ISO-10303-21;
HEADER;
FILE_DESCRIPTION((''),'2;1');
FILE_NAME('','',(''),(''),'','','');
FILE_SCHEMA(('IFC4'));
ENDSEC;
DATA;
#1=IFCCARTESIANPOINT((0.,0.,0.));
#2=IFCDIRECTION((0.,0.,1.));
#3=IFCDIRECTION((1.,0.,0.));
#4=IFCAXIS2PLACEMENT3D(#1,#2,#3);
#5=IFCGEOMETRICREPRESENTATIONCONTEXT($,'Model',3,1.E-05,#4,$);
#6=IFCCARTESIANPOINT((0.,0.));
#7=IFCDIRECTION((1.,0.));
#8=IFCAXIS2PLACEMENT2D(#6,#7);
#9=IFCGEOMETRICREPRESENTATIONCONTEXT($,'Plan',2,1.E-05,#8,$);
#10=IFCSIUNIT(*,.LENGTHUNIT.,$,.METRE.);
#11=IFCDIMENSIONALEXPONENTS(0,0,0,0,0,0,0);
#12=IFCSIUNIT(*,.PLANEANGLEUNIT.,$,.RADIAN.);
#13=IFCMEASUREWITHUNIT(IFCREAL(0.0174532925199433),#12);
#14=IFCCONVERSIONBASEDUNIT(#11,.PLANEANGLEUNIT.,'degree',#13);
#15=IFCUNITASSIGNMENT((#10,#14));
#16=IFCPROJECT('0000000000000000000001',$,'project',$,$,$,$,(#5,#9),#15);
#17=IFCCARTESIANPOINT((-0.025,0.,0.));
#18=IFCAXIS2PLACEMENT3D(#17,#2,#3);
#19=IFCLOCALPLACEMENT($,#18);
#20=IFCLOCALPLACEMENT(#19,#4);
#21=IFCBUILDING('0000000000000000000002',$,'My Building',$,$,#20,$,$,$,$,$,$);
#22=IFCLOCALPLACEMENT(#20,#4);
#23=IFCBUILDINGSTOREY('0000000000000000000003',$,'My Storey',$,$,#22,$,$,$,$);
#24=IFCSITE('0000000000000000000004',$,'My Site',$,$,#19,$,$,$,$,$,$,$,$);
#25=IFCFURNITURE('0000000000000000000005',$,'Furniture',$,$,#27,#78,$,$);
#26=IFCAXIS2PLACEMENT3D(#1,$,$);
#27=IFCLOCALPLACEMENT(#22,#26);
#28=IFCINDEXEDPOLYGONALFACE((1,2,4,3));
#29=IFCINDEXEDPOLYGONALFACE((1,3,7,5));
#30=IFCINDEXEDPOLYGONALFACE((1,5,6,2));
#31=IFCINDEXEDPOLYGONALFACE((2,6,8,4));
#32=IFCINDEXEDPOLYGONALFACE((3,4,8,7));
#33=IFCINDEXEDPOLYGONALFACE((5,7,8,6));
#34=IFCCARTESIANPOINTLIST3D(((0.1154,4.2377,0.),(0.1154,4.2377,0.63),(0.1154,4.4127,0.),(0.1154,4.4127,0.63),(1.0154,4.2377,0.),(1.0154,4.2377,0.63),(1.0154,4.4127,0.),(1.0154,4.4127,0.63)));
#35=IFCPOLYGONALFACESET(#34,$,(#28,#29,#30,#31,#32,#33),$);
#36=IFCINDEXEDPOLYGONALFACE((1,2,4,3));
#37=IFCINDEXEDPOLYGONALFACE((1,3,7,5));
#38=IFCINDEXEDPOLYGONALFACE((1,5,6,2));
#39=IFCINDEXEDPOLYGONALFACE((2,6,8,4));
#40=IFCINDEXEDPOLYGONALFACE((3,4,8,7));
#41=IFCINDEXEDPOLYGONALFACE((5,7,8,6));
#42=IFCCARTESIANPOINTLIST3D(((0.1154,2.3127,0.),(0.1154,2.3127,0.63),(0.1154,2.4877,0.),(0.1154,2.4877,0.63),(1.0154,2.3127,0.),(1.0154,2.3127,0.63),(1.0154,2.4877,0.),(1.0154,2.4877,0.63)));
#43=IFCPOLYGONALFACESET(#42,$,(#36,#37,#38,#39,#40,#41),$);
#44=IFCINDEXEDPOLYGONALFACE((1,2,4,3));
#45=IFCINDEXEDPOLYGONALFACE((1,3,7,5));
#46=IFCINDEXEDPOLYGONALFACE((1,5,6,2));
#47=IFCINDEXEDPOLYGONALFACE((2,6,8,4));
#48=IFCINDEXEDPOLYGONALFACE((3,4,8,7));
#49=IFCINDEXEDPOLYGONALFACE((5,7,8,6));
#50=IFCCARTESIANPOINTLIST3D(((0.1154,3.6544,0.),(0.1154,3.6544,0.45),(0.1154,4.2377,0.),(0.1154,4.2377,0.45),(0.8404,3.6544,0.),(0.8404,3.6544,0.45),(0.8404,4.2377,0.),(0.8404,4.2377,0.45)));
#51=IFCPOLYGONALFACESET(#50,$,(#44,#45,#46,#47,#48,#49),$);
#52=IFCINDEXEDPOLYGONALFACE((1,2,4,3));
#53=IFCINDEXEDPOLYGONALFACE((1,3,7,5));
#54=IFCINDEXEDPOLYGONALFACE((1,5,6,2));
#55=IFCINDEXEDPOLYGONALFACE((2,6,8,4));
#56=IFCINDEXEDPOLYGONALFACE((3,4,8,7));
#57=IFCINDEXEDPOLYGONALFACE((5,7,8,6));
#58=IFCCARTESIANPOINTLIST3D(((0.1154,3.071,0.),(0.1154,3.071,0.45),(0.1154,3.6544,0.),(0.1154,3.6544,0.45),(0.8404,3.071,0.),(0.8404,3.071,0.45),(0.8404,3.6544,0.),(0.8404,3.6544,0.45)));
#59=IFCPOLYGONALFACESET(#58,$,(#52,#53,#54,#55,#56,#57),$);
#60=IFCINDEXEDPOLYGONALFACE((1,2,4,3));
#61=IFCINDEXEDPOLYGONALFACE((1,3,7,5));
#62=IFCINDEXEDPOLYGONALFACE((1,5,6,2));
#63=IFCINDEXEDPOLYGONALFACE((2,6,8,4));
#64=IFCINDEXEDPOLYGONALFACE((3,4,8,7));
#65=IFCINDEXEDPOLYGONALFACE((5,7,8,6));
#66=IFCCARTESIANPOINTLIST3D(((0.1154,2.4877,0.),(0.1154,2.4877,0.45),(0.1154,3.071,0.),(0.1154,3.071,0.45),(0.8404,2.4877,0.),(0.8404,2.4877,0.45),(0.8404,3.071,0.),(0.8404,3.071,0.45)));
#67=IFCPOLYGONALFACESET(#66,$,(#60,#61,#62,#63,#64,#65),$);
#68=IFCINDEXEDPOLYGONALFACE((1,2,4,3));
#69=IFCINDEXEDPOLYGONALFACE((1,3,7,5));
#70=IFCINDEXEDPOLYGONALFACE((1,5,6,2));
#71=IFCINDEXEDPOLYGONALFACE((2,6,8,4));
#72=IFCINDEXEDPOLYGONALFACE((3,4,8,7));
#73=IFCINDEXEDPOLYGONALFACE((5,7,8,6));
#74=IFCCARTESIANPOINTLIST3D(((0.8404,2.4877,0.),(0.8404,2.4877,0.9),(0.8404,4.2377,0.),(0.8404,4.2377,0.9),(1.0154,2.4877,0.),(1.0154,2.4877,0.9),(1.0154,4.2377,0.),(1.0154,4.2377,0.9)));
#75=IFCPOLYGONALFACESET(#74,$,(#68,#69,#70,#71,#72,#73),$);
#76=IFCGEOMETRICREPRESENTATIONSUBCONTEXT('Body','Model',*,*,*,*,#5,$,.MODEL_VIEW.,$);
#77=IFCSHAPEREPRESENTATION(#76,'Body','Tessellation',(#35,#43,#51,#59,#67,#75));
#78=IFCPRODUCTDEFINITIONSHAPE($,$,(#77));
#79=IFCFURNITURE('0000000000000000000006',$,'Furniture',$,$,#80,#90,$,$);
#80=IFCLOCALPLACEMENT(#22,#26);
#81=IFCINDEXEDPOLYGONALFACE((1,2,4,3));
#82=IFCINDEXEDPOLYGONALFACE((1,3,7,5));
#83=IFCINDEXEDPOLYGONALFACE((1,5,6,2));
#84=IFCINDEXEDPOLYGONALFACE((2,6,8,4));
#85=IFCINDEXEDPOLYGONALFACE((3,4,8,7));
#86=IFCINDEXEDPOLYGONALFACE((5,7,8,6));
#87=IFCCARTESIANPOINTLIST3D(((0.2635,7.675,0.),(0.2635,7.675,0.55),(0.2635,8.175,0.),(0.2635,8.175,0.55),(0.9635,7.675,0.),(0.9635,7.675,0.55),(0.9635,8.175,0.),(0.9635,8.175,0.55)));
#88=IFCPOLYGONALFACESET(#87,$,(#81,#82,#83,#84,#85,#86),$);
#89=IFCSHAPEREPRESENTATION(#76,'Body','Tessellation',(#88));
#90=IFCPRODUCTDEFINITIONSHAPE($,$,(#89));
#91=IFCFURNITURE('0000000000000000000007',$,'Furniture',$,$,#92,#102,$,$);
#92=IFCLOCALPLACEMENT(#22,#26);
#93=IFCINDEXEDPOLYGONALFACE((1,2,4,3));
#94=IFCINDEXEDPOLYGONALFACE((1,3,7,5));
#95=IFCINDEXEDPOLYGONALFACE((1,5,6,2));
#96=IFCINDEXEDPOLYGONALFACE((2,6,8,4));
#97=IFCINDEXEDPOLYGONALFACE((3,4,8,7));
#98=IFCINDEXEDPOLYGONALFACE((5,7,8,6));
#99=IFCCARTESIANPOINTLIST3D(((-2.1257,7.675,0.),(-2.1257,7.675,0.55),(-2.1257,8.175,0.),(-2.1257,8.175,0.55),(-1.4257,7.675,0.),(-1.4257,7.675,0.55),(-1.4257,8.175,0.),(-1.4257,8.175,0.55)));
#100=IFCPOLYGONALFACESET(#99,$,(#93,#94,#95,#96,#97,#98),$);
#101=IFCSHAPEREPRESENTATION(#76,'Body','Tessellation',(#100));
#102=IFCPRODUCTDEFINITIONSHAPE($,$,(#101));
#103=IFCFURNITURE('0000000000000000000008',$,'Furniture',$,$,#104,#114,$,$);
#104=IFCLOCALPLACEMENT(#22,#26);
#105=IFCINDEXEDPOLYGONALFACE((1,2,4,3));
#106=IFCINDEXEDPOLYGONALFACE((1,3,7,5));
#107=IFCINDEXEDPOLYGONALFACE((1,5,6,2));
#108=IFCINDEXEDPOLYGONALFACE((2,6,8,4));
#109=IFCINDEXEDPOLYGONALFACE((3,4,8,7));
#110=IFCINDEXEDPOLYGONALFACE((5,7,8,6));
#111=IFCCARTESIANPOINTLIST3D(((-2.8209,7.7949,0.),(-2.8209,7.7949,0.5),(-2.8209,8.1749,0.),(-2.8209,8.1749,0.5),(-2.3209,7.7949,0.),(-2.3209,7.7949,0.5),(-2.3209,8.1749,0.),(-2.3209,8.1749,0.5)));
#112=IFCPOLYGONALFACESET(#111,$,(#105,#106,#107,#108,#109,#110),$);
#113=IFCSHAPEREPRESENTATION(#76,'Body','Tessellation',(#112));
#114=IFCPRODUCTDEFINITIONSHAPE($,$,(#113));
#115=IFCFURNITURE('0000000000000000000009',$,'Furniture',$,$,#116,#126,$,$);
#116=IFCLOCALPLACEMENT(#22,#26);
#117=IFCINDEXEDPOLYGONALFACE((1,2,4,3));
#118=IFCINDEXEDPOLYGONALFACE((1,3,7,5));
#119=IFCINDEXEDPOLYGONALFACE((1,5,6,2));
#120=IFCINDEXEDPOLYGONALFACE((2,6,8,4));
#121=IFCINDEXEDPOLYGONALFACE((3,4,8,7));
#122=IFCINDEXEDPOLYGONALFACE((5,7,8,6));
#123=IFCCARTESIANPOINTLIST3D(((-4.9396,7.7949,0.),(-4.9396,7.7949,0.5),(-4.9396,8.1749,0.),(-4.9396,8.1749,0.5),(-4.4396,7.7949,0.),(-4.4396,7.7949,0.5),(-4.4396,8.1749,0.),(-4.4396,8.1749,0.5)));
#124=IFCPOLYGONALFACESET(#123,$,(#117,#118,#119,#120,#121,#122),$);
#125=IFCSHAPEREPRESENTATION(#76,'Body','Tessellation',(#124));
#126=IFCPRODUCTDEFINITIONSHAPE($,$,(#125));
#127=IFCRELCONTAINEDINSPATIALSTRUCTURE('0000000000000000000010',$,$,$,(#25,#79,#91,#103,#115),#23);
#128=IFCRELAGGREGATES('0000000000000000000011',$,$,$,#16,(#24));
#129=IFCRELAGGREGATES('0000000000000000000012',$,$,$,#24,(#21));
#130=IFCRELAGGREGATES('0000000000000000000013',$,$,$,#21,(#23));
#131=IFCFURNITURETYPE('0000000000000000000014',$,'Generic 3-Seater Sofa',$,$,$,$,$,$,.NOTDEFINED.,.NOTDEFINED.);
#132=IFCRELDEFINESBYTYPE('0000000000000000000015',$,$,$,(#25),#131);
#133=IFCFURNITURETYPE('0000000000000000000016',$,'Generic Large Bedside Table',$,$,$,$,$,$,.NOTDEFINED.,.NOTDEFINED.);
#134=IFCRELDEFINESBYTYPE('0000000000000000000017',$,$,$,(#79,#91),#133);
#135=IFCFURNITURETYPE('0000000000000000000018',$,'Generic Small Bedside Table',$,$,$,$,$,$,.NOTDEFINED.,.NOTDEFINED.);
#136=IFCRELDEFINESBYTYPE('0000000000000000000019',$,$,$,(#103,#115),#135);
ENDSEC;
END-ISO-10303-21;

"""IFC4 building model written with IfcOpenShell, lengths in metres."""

from ifc_helpers import new_model, entity, si_unit, converted_unit, frame, origin_with_axes, origin_2d_with_axis, place, context, subcontext, project, spatial, line, indexed_curve, outline, extrude, shape, source, transform, mapped, type_object, type_shapes, element, save


model = new_model("IFC4")

# Units and contexts
model_context = context("Model", 3, precision=1e-05, world=origin_with_axes())
plan_context = context("Plan", 2, precision=1e-05, world=origin_2d_with_axis())
body_context_1 = subcontext(model_context, "Body", "Model", "MODEL_VIEW")
body_context_2 = subcontext(plan_context, "Body", "Plan", "PLAN_VIEW")
ifc_project = project(units=[si_unit("LENGTHUNIT", "METRE"), converted_unit("PLANEANGLEUNIT", "degree", entity("IfcReal", 0.0174532925199433), si_unit("PLANEANGLEUNIT", "RADIAN"), dimensions=[0, 0, 0, 0, 0, 0, 0])], contexts=[model_context, plan_context])

# Site, building, storey
site_placement = place(None, frame((-0.025, 0.0, 0.0), z_axis=(0.0, 0.0, 1.0), x_axis=(1.0, 0.0, 0.0)))
site = spatial("IfcSite", under=ifc_project, at=site_placement, Name="My Site")
building_placement = place(site_placement, origin_with_axes())
building = spatial("IfcBuilding", under=site, at=building_placement, Name="My Building")
storey_placement = place(building_placement, origin_with_axes())
storey = spatial("IfcBuildingStorey", under=building, at=storey_placement, Name="My Storey")

# Furniture
furniture_type_1 = type_object("IfcFurnitureType", Name="Generic 3-Seater Sofa", AssemblyPlace="NOTDEFINED", PredefinedType="NOTDEFINED")
shared_shape_1 = source(origin_with_axes(), body_context_1, "Body", "SweptSolid", [
    extrude(outline(indexed_curve([(0.0, 0.0), (0.175, 0.0), (0.175, 0.9), (0.0, 0.9)], segments=[line(1, 2, 3, 4, 1)])), frame((-1.05, -0.9, 0.0), z_axis=(0.0, 0.0, 1.0), x_axis=(1.0, 0.0, 0.0)), (0.0, 0.0, 1.0), 0.63),
    extrude(outline(indexed_curve([(0.0, 0.0), (0.175, 0.0), (0.175, 0.9), (0.0, 0.9)], segments=[line(1, 2, 3, 4, 1)])), frame((0.875, -0.9, 0.0), z_axis=(0.0, 0.0, 1.0), x_axis=(1.0, 0.0, 0.0)), (0.0, 0.0, 1.0), 0.63),
    extrude(outline(indexed_curve([(0.175, 0.0), (0.7583, 0.0), (0.7583, 0.725), (0.175, 0.725)], segments=[line(1, 2, 3, 4, 1)])), frame((-1.05, -0.9, 0.0), z_axis=(0.0, 0.0, 1.0), x_axis=(1.0, 0.0, 0.0)), (0.0, 0.0, 1.0), 0.45),
    extrude(outline(indexed_curve([(0.7583, 0.0), (1.3417, 0.0), (1.3417, 0.725), (0.7583, 0.725)], segments=[line(1, 2, 3, 4, 1)])), frame((-1.05, -0.9, 0.0), z_axis=(0.0, 0.0, 1.0), x_axis=(1.0, 0.0, 0.0)), (0.0, 0.0, 1.0), 0.45),
    extrude(outline(indexed_curve([(1.3417, 0.0), (1.925, 0.0), (1.925, 0.725), (1.3417, 0.725)], segments=[line(1, 2, 3, 4, 1)])), frame((-1.05, -0.9, 0.0), z_axis=(0.0, 0.0, 1.0), x_axis=(1.0, 0.0, 0.0)), (0.0, 0.0, 1.0), 0.45),
    extrude(outline(indexed_curve([(0.175, 0.725), (1.925, 0.725), (1.925, 0.9), (0.175, 0.9)], segments=[line(1, 2, 3, 4, 1)])), frame((-1.05, -0.9, 0.0), z_axis=(0.0, 0.0, 1.0), x_axis=(1.0, 0.0, 0.0)), (0.0, 0.0, 1.0), 0.9),
])
shared_shape_2 = source(origin_with_axes(), body_context_2, "Body", "Curve2D", [
    entity("IfcIndexedPolyCurve", entity("IfcCartesianPointList2D", [[-1.05, -0.9], [-0.875, -0.9], [-0.875, 0.0], [-1.05, 0.0]]), [entity("IfcLineIndex", [1, 2, 3, 4, 1])]),
    entity("IfcIndexedPolyCurve", entity("IfcCartesianPointList2D", [[0.875, -0.9], [1.05, -0.9], [1.05, 0.0], [0.875, 0.0]]), [entity("IfcLineIndex", [1, 2, 3, 4, 1])]),
    entity("IfcIndexedPolyCurve", entity("IfcCartesianPointList2D", [[-0.875, -0.9], [-0.2917, -0.9], [-0.2917, -0.175], [-0.875, -0.175]]), [entity("IfcLineIndex", [1, 2, 3, 4, 1])]),
    entity("IfcIndexedPolyCurve", entity("IfcCartesianPointList2D", [[-0.2917, -0.9], [0.2917, -0.9], [0.2917, -0.175], [-0.2917, -0.175]]), [entity("IfcLineIndex", [1, 2, 3, 4, 1])]),
    entity("IfcIndexedPolyCurve", entity("IfcCartesianPointList2D", [[0.2917, -0.9], [0.875, -0.9], [0.875, -0.175], [0.2917, -0.175]]), [entity("IfcLineIndex", [1, 2, 3, 4, 1])]),
    entity("IfcIndexedPolyCurve", entity("IfcCartesianPointList2D", [[-0.875, -0.175], [0.875, -0.175], [0.875, 0.0], [-0.875, 0.0]]), [entity("IfcLineIndex", [1, 2, 3, 4, 1])]),
])
type_shapes(furniture_type_1, [shared_shape_1, shared_shape_2])
furniture_1_placement = place(storey_placement, frame((1.0154, 3.3627, 0.0), z_axis=(0.0, 0.0, 1.0), x_axis=(0.0, -1.0, 0.0)))
element("IfcFurniture", 1, at=furniture_1_placement, inside=storey, type_object=furniture_type_1, Name="Furniture", shapes=[
    shape(body_context_1, "Body", "MappedRepresentation", [mapped(shared_shape_1, transform((0.0, 0.0, 0.0), x_axis=(1.0, 0.0, 0.0), y_axis=(0.0, 1.0, 0.0), z_axis=(0.0, 0.0, 1.0), scale=1.0))]),
    shape(body_context_2, "Body", "MappedRepresentation", [mapped(shared_shape_2, transform((0.0, 0.0, 0.0), x_axis=(1.0, 0.0, 0.0), y_axis=(0.0, 1.0, 0.0), z_axis=(0.0, 0.0, 1.0), scale=1.0))]),
])
furniture_type_2 = type_object("IfcFurnitureType", Name="Generic Large Bedside Table", AssemblyPlace="NOTDEFINED", PredefinedType="NOTDEFINED")
shared_shape_3 = source(origin_with_axes(), body_context_1, "Body", "SweptSolid", [
    extrude(outline(indexed_curve([(0.0, 0.0), (0.7, 0.0), (0.7, 0.5), (0.0, 0.5)], segments=[line(1, 2, 3, 4, 1)])), frame((-0.35, -0.25, 0.0), z_axis=(0.0, 0.0, 1.0), x_axis=(1.0, 0.0, 0.0)), (0.0, 0.0, 1.0), 0.55),
])
shared_shape_4 = source(origin_with_axes(), body_context_2, "Body", "Curve2D", [
    entity("IfcIndexedPolyCurve", entity("IfcCartesianPointList2D", [[-0.35, -0.25], [0.35, -0.25], [0.35, 0.25], [-0.35, 0.25]]), [entity("IfcLineIndex", [1, 2, 3, 4, 1])]),
])
type_shapes(furniture_type_2, [shared_shape_3, shared_shape_4])
for number, where, z_axis, x_axis, name in (
    (2, (0.6135, 7.925, 0.0), (0.0, 0.0, 1.0), (1.0, 0.0, 0.0), "Furniture"),
    (3, (-1.7757, 7.925, 0.0), (0.0, 0.0, 1.0), (1.0, 0.0, 0.0), "Furniture"),
):
    element("IfcFurniture", number, at=place(storey_placement, frame(where, z_axis=z_axis, x_axis=x_axis)), inside=storey, type_object=furniture_type_2, Name=name, shapes=[
        shape(body_context_1, "Body", "MappedRepresentation", [mapped(shared_shape_3, transform((0.0, 0.0, 0.0), x_axis=(1.0, 0.0, 0.0), y_axis=(0.0, 1.0, 0.0), z_axis=(0.0, 0.0, 1.0), scale=1.0))]),
        shape(body_context_2, "Body", "MappedRepresentation", [mapped(shared_shape_4, transform((0.0, 0.0, 0.0), x_axis=(1.0, 0.0, 0.0), y_axis=(0.0, 1.0, 0.0), z_axis=(0.0, 0.0, 1.0), scale=1.0))]),
    ])
furniture_type_3 = type_object("IfcFurnitureType", Name="Generic Small Bedside Table", AssemblyPlace="NOTDEFINED", PredefinedType="NOTDEFINED")
shared_shape_5 = source(origin_with_axes(), body_context_1, "Body", "SweptSolid", [
    extrude(outline(indexed_curve([(0.0, 0.0), (0.5, 0.0), (0.5, 0.38), (0.0, 0.38)], segments=[line(1, 2, 3, 4, 1)])), frame((-0.25, -0.19, 0.0), z_axis=(0.0, 0.0, 1.0), x_axis=(1.0, 0.0, 0.0)), (0.0, 0.0, 1.0), 0.5),
])
shared_shape_6 = source(origin_with_axes(), body_context_2, "Body", "Curve2D", [
    entity("IfcIndexedPolyCurve", entity("IfcCartesianPointList2D", [[-0.25, -0.19], [0.25, -0.19], [0.25, 0.19], [-0.25, 0.19]]), [entity("IfcLineIndex", [1, 2, 3, 4, 1])]),
])
type_shapes(furniture_type_3, [shared_shape_5, shared_shape_6])
for number, where, z_axis, x_axis, name in (
    (4, (-2.5709, 7.9849, 0.0), (0.0, 0.0, 1.0), (1.0, 0.0, 0.0), "Furniture"),
    (5, (-4.6896, 7.9849, 0.0), (0.0, 0.0, 1.0), (1.0, 0.0, 0.0), "Furniture"),
):
    element("IfcFurniture", number, at=place(storey_placement, frame(where, z_axis=z_axis, x_axis=x_axis)), inside=storey, type_object=furniture_type_3, Name=name, shapes=[
        shape(body_context_1, "Body", "MappedRepresentation", [mapped(shared_shape_5, transform((0.0, 0.0, 0.0), x_axis=(1.0, 0.0, 0.0), y_axis=(0.0, 1.0, 0.0), z_axis=(0.0, 0.0, 1.0), scale=1.0))]),
        shape(body_context_2, "Body", "MappedRepresentation", [mapped(shared_shape_6, transform((0.0, 0.0, 0.0), x_axis=(1.0, 0.0, 0.0), y_axis=(0.0, 1.0, 0.0), z_axis=(0.0, 0.0, 1.0), scale=1.0))]),
    ])

save(model, "model.ifc")
